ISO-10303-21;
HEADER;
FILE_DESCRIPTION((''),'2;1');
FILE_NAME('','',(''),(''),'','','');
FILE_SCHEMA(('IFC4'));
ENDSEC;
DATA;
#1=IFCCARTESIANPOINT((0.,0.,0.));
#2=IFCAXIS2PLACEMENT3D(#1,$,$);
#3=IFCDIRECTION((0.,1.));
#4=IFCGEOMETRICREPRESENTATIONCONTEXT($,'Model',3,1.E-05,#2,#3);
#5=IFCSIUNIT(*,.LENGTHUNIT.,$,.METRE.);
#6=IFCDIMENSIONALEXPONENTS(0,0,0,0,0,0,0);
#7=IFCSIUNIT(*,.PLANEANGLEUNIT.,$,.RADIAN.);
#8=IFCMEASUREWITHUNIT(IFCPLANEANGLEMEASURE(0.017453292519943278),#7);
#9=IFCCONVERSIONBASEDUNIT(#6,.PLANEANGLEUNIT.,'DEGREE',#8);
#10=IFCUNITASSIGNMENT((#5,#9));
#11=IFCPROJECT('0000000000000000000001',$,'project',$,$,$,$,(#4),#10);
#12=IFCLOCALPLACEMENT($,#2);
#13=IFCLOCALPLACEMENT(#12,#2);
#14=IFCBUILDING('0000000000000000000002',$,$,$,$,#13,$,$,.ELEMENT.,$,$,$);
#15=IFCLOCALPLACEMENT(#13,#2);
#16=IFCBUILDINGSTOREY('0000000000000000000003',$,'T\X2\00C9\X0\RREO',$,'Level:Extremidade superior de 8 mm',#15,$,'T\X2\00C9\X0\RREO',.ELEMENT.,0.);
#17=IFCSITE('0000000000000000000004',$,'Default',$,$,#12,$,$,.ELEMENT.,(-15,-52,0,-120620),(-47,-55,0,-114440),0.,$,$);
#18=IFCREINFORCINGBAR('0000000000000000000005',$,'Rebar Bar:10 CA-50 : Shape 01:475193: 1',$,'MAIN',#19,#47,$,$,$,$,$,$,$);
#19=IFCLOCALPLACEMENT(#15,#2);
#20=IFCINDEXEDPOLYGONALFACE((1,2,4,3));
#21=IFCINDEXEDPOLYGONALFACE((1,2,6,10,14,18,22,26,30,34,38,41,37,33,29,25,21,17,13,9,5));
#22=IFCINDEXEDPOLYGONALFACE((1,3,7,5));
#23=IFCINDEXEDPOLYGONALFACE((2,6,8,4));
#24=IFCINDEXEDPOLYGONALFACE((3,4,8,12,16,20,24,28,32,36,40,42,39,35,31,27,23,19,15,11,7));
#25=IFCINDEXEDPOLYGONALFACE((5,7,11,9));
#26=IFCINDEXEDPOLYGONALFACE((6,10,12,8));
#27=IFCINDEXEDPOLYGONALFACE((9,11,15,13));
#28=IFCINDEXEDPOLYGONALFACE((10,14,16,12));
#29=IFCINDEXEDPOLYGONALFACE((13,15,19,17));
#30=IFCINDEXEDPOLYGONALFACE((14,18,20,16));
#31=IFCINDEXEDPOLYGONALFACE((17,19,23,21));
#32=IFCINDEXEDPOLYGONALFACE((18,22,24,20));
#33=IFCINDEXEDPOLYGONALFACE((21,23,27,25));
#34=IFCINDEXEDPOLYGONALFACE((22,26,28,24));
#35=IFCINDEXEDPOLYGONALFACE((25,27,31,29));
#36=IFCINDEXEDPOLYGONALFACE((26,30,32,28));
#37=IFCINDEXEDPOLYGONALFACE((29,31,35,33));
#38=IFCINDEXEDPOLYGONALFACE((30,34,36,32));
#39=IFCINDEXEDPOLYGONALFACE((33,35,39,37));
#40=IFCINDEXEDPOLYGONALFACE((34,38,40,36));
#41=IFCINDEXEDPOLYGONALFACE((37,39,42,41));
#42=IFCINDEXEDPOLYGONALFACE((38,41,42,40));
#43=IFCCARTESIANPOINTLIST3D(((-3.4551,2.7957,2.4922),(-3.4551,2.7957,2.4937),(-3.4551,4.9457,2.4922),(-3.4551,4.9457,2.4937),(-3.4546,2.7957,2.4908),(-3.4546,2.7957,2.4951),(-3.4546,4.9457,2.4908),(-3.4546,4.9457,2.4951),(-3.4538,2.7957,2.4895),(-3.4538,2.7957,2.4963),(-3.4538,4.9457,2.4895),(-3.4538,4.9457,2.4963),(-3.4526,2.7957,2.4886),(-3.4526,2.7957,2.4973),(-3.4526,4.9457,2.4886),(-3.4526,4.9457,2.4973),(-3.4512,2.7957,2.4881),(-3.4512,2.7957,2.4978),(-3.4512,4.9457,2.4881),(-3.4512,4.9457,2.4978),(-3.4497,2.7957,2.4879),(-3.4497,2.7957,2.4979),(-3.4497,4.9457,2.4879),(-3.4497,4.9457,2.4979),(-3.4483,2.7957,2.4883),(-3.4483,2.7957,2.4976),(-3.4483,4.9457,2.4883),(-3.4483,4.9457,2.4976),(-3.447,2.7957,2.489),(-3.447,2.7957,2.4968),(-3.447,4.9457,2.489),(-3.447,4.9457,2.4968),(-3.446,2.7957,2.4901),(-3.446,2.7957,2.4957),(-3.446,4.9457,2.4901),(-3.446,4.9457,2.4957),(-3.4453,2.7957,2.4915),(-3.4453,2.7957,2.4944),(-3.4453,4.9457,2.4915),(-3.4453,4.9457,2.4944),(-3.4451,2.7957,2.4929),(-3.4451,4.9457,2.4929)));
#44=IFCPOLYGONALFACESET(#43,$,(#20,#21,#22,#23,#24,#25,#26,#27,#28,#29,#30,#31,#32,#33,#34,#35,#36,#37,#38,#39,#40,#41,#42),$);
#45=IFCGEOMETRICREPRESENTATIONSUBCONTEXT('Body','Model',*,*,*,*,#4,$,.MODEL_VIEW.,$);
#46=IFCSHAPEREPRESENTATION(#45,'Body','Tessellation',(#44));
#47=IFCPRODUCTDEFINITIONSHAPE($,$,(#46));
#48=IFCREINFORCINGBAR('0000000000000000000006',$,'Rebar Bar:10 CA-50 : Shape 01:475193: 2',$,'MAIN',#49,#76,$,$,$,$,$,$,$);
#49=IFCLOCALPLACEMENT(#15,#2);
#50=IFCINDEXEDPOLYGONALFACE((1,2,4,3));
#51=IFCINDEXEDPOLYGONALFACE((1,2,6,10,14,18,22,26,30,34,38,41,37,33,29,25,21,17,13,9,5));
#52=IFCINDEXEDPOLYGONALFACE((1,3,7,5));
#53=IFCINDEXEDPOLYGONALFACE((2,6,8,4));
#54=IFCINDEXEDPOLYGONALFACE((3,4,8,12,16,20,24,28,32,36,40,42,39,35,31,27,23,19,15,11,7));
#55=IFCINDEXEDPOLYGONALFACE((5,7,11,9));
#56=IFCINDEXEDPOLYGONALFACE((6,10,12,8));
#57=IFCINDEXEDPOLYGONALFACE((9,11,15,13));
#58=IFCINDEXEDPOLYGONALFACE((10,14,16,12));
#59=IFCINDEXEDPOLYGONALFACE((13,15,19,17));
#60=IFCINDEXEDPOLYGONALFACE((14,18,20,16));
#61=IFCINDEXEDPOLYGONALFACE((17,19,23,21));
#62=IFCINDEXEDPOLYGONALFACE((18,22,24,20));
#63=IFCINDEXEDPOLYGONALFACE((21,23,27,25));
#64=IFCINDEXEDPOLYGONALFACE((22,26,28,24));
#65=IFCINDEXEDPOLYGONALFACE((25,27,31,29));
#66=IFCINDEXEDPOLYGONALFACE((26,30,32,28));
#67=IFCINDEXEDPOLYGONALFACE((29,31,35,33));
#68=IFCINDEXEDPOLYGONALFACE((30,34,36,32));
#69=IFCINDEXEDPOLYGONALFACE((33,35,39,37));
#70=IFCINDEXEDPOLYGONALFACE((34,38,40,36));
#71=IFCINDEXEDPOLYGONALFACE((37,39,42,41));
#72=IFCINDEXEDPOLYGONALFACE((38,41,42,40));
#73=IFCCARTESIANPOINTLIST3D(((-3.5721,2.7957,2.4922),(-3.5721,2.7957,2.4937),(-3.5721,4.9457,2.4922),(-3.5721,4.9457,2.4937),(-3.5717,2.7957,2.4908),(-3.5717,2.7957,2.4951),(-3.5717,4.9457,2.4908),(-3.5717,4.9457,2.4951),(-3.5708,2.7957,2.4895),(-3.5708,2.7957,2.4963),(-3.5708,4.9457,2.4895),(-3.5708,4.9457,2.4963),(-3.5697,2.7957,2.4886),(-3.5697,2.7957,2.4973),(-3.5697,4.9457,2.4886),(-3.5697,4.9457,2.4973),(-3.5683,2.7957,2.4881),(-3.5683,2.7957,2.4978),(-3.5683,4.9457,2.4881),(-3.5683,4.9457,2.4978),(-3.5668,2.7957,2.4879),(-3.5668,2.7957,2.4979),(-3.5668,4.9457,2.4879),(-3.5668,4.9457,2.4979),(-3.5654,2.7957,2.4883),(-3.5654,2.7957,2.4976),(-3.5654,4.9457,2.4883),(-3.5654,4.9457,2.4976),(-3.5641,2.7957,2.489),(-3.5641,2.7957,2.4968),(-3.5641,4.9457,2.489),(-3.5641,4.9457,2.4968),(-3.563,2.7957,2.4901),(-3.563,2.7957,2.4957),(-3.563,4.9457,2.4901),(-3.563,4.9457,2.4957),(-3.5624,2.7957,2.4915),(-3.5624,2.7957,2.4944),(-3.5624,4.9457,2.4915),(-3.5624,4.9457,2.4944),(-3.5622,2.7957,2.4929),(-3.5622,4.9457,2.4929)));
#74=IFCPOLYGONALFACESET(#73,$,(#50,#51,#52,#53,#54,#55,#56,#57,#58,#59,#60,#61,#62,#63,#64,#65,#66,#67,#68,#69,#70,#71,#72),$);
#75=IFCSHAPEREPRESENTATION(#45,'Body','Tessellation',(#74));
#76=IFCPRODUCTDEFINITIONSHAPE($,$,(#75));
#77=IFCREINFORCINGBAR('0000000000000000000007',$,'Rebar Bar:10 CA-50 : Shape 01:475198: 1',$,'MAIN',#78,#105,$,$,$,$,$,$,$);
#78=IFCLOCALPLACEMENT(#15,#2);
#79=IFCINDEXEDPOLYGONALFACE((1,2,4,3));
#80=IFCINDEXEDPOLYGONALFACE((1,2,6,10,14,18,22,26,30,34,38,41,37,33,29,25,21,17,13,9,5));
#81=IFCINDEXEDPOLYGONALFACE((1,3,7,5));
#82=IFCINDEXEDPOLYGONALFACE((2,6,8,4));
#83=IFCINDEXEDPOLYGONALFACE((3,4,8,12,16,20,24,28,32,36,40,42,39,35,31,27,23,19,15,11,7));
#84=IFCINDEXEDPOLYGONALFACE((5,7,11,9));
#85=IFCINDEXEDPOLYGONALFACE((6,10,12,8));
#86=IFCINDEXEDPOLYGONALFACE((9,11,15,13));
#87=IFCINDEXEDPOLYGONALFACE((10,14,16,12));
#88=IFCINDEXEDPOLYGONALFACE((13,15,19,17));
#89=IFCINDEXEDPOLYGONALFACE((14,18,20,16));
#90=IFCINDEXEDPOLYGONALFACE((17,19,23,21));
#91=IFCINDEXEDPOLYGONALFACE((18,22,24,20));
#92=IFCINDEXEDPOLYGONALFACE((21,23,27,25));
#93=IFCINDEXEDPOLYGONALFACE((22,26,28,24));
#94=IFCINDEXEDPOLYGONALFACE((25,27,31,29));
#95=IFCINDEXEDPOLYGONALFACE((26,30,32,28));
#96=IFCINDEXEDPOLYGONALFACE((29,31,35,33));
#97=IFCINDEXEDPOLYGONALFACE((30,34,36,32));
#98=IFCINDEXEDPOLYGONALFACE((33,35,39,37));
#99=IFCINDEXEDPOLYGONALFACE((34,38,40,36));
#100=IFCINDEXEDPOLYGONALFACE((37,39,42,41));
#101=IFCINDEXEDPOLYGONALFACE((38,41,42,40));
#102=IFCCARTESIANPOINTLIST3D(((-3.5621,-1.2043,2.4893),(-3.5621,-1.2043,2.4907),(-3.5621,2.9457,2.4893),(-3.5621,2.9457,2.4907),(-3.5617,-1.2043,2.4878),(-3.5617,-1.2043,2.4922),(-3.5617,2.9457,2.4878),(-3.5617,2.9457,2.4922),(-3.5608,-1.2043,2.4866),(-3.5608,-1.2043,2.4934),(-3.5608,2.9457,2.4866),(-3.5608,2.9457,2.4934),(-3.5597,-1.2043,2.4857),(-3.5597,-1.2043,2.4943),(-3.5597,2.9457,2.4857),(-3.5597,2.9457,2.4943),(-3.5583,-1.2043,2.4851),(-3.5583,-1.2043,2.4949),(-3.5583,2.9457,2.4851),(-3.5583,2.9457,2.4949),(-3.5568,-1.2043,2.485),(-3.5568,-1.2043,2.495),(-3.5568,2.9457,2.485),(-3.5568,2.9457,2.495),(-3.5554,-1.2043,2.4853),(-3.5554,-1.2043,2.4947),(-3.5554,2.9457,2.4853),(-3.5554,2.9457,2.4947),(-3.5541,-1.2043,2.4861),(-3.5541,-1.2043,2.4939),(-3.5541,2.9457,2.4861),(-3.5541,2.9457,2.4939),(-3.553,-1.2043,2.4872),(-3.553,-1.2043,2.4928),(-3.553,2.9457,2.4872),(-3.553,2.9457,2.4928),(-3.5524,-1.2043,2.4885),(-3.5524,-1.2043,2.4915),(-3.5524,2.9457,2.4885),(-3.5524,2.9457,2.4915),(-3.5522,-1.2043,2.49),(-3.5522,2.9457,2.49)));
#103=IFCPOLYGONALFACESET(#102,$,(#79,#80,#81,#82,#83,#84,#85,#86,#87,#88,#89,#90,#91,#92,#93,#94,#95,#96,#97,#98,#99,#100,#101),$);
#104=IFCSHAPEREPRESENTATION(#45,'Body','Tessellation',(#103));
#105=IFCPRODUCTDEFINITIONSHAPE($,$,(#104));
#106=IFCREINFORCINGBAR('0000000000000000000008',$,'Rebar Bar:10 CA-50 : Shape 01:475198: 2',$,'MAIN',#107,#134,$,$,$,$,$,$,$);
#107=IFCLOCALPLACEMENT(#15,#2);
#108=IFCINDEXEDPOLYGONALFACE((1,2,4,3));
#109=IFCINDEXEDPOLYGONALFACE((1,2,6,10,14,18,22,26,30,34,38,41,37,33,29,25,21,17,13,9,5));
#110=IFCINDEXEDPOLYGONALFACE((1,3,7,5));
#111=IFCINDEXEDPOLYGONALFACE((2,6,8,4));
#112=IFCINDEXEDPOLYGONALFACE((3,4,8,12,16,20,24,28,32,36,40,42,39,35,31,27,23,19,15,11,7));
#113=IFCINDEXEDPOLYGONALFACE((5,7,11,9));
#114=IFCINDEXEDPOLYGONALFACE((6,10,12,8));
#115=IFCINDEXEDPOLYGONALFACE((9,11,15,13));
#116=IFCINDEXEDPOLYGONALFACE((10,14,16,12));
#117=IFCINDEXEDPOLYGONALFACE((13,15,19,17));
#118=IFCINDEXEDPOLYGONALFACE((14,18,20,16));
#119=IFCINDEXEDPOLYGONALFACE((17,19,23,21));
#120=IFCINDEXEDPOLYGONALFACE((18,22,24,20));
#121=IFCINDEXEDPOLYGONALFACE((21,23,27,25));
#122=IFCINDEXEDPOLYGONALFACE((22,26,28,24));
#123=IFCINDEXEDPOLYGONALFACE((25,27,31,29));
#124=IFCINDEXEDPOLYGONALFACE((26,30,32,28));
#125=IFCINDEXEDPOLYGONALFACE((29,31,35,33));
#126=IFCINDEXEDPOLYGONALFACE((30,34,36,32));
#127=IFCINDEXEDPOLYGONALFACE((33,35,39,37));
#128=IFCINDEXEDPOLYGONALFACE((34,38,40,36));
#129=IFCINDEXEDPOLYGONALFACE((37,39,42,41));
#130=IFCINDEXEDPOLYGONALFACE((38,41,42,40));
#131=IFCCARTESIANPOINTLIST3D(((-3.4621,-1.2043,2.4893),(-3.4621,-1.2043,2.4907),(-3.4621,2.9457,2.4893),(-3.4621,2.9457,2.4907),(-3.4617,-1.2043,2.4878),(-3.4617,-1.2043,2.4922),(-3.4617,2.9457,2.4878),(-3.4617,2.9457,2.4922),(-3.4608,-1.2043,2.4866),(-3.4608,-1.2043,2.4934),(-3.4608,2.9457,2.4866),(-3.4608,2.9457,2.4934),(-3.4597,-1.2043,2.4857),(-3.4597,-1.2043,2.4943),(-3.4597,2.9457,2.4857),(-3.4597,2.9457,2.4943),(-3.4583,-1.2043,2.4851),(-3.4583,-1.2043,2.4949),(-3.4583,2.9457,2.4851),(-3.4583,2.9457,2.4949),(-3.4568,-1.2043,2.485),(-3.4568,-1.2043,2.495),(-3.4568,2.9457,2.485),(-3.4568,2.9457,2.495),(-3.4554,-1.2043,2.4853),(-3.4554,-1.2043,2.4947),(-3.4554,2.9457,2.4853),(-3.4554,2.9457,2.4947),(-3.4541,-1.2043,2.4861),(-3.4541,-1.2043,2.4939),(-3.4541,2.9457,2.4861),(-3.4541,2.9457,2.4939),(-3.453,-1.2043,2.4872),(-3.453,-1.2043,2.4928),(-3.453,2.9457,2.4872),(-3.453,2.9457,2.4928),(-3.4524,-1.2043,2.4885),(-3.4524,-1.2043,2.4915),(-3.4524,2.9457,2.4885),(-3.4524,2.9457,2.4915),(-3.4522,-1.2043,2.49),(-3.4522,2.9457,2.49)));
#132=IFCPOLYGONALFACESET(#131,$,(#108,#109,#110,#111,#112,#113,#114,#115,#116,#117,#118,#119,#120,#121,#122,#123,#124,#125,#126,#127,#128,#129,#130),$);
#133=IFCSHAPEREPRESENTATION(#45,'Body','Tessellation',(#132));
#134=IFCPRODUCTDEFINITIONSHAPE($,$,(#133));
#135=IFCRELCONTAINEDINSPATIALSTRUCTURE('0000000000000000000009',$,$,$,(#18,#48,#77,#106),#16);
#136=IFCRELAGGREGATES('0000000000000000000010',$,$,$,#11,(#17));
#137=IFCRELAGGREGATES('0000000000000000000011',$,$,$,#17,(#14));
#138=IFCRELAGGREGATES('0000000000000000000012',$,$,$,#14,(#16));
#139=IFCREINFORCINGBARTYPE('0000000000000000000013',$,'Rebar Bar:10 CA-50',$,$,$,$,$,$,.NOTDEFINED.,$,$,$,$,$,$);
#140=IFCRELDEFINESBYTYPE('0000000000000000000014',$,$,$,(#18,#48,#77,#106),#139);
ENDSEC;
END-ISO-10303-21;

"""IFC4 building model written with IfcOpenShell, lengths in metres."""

from ifc_helpers import new_model, entity, si_unit, converted_unit, direction, origin, place, context, subcontext, project, spatial, type_object, element, save


model = new_model("IFC4")

# Units and contexts
model_context = context("Model", 3, precision=1e-05, world=origin(), true_north=direction((0.0, 1.0)))
body_context = subcontext(model_context, "Body", "Model", "MODEL_VIEW")
ifc_project = project(units=[si_unit("LENGTHUNIT", "METRE"), converted_unit("PLANEANGLEUNIT", "DEGREE", entity("IfcPlaneAngleMeasure", 0.017453292519943278), si_unit("PLANEANGLEUNIT", "RADIAN"), dimensions=[0, 0, 0, 0, 0, 0, 0])], contexts=[model_context])

# Site, building, storey
site_placement = place(None, origin())
site = spatial("IfcSite", under=ifc_project, at=site_placement, Name="Default", CompositionType="ELEMENT", RefLatitude=(-15, -52, 0, -120620), RefLongitude=(-47, -55, 0, -114440), RefElevation=0.0)
building_placement = place(site_placement, origin())
building = spatial("IfcBuilding", under=site, at=building_placement, CompositionType="ELEMENT")
storey_placement = place(building_placement, origin())
storey = spatial("IfcBuildingStorey", under=building, at=storey_placement, Name="TÉRREO", ObjectType="Level:Extremidade superior de 8 mm", LongName="TÉRREO", CompositionType="ELEMENT", Elevation=0.0)

# Reinforcing bars
reinforcing_bar_type_1 = type_object("IfcReinforcingBarType", Name="Rebar Bar:10 CA-50", PredefinedType="NOTDEFINED")
reinforcing_bar_1_placement = place(storey_placement, origin())
element("IfcReinforcingBar", 1, at=reinforcing_bar_1_placement, inside=storey, type_object=reinforcing_bar_type_1, Name="Rebar Bar:10 CA-50 : Shape 01:475193: 1", ObjectType="MAIN", context=body_context, shape_type="AdvancedSweptSolid", body=[
    entity("IfcSweptDiskSolid", entity("IfcIndexedPolyCurve", entity("IfcCartesianPointList3D", [[-3.4501, 2.7957, 2.4929], [-3.4501, 4.9457, 2.4929]]), None, False), 0.005, None, 0.0, 1.0),
])
reinforcing_bar_2_placement = place(storey_placement, origin())
element("IfcReinforcingBar", 2, at=reinforcing_bar_2_placement, inside=storey, type_object=reinforcing_bar_type_1, Name="Rebar Bar:10 CA-50 : Shape 01:475193: 2", ObjectType="MAIN", context=body_context, shape_type="AdvancedSweptSolid", body=[
    entity("IfcSweptDiskSolid", entity("IfcIndexedPolyCurve", entity("IfcCartesianPointList3D", [[-3.5672, 2.7957, 2.4929], [-3.5672, 4.9457, 2.4929]]), None, False), 0.005, None, 0.0, 1.0),
])
reinforcing_bar_3_placement = place(storey_placement, origin())
element("IfcReinforcingBar", 3, at=reinforcing_bar_3_placement, inside=storey, type_object=reinforcing_bar_type_1, Name="Rebar Bar:10 CA-50 : Shape 01:475198: 1", ObjectType="MAIN", context=body_context, shape_type="AdvancedSweptSolid", body=[
    entity("IfcSweptDiskSolid", entity("IfcIndexedPolyCurve", entity("IfcCartesianPointList3D", [[-3.5572, -1.2043, 2.49], [-3.5572, 2.9457, 2.49]]), None, False), 0.005, None, 0.0, 1.0),
])
reinforcing_bar_4_placement = place(storey_placement, origin())
element("IfcReinforcingBar", 4, at=reinforcing_bar_4_placement, inside=storey, type_object=reinforcing_bar_type_1, Name="Rebar Bar:10 CA-50 : Shape 01:475198: 2", ObjectType="MAIN", context=body_context, shape_type="AdvancedSweptSolid", body=[
    entity("IfcSweptDiskSolid", entity("IfcIndexedPolyCurve", entity("IfcCartesianPointList3D", [[-3.4572, -1.2043, 2.49], [-3.4572, 2.9457, 2.49]]), None, False), 0.005, None, 0.0, 1.0),
])

save(model, "model.ifc")
